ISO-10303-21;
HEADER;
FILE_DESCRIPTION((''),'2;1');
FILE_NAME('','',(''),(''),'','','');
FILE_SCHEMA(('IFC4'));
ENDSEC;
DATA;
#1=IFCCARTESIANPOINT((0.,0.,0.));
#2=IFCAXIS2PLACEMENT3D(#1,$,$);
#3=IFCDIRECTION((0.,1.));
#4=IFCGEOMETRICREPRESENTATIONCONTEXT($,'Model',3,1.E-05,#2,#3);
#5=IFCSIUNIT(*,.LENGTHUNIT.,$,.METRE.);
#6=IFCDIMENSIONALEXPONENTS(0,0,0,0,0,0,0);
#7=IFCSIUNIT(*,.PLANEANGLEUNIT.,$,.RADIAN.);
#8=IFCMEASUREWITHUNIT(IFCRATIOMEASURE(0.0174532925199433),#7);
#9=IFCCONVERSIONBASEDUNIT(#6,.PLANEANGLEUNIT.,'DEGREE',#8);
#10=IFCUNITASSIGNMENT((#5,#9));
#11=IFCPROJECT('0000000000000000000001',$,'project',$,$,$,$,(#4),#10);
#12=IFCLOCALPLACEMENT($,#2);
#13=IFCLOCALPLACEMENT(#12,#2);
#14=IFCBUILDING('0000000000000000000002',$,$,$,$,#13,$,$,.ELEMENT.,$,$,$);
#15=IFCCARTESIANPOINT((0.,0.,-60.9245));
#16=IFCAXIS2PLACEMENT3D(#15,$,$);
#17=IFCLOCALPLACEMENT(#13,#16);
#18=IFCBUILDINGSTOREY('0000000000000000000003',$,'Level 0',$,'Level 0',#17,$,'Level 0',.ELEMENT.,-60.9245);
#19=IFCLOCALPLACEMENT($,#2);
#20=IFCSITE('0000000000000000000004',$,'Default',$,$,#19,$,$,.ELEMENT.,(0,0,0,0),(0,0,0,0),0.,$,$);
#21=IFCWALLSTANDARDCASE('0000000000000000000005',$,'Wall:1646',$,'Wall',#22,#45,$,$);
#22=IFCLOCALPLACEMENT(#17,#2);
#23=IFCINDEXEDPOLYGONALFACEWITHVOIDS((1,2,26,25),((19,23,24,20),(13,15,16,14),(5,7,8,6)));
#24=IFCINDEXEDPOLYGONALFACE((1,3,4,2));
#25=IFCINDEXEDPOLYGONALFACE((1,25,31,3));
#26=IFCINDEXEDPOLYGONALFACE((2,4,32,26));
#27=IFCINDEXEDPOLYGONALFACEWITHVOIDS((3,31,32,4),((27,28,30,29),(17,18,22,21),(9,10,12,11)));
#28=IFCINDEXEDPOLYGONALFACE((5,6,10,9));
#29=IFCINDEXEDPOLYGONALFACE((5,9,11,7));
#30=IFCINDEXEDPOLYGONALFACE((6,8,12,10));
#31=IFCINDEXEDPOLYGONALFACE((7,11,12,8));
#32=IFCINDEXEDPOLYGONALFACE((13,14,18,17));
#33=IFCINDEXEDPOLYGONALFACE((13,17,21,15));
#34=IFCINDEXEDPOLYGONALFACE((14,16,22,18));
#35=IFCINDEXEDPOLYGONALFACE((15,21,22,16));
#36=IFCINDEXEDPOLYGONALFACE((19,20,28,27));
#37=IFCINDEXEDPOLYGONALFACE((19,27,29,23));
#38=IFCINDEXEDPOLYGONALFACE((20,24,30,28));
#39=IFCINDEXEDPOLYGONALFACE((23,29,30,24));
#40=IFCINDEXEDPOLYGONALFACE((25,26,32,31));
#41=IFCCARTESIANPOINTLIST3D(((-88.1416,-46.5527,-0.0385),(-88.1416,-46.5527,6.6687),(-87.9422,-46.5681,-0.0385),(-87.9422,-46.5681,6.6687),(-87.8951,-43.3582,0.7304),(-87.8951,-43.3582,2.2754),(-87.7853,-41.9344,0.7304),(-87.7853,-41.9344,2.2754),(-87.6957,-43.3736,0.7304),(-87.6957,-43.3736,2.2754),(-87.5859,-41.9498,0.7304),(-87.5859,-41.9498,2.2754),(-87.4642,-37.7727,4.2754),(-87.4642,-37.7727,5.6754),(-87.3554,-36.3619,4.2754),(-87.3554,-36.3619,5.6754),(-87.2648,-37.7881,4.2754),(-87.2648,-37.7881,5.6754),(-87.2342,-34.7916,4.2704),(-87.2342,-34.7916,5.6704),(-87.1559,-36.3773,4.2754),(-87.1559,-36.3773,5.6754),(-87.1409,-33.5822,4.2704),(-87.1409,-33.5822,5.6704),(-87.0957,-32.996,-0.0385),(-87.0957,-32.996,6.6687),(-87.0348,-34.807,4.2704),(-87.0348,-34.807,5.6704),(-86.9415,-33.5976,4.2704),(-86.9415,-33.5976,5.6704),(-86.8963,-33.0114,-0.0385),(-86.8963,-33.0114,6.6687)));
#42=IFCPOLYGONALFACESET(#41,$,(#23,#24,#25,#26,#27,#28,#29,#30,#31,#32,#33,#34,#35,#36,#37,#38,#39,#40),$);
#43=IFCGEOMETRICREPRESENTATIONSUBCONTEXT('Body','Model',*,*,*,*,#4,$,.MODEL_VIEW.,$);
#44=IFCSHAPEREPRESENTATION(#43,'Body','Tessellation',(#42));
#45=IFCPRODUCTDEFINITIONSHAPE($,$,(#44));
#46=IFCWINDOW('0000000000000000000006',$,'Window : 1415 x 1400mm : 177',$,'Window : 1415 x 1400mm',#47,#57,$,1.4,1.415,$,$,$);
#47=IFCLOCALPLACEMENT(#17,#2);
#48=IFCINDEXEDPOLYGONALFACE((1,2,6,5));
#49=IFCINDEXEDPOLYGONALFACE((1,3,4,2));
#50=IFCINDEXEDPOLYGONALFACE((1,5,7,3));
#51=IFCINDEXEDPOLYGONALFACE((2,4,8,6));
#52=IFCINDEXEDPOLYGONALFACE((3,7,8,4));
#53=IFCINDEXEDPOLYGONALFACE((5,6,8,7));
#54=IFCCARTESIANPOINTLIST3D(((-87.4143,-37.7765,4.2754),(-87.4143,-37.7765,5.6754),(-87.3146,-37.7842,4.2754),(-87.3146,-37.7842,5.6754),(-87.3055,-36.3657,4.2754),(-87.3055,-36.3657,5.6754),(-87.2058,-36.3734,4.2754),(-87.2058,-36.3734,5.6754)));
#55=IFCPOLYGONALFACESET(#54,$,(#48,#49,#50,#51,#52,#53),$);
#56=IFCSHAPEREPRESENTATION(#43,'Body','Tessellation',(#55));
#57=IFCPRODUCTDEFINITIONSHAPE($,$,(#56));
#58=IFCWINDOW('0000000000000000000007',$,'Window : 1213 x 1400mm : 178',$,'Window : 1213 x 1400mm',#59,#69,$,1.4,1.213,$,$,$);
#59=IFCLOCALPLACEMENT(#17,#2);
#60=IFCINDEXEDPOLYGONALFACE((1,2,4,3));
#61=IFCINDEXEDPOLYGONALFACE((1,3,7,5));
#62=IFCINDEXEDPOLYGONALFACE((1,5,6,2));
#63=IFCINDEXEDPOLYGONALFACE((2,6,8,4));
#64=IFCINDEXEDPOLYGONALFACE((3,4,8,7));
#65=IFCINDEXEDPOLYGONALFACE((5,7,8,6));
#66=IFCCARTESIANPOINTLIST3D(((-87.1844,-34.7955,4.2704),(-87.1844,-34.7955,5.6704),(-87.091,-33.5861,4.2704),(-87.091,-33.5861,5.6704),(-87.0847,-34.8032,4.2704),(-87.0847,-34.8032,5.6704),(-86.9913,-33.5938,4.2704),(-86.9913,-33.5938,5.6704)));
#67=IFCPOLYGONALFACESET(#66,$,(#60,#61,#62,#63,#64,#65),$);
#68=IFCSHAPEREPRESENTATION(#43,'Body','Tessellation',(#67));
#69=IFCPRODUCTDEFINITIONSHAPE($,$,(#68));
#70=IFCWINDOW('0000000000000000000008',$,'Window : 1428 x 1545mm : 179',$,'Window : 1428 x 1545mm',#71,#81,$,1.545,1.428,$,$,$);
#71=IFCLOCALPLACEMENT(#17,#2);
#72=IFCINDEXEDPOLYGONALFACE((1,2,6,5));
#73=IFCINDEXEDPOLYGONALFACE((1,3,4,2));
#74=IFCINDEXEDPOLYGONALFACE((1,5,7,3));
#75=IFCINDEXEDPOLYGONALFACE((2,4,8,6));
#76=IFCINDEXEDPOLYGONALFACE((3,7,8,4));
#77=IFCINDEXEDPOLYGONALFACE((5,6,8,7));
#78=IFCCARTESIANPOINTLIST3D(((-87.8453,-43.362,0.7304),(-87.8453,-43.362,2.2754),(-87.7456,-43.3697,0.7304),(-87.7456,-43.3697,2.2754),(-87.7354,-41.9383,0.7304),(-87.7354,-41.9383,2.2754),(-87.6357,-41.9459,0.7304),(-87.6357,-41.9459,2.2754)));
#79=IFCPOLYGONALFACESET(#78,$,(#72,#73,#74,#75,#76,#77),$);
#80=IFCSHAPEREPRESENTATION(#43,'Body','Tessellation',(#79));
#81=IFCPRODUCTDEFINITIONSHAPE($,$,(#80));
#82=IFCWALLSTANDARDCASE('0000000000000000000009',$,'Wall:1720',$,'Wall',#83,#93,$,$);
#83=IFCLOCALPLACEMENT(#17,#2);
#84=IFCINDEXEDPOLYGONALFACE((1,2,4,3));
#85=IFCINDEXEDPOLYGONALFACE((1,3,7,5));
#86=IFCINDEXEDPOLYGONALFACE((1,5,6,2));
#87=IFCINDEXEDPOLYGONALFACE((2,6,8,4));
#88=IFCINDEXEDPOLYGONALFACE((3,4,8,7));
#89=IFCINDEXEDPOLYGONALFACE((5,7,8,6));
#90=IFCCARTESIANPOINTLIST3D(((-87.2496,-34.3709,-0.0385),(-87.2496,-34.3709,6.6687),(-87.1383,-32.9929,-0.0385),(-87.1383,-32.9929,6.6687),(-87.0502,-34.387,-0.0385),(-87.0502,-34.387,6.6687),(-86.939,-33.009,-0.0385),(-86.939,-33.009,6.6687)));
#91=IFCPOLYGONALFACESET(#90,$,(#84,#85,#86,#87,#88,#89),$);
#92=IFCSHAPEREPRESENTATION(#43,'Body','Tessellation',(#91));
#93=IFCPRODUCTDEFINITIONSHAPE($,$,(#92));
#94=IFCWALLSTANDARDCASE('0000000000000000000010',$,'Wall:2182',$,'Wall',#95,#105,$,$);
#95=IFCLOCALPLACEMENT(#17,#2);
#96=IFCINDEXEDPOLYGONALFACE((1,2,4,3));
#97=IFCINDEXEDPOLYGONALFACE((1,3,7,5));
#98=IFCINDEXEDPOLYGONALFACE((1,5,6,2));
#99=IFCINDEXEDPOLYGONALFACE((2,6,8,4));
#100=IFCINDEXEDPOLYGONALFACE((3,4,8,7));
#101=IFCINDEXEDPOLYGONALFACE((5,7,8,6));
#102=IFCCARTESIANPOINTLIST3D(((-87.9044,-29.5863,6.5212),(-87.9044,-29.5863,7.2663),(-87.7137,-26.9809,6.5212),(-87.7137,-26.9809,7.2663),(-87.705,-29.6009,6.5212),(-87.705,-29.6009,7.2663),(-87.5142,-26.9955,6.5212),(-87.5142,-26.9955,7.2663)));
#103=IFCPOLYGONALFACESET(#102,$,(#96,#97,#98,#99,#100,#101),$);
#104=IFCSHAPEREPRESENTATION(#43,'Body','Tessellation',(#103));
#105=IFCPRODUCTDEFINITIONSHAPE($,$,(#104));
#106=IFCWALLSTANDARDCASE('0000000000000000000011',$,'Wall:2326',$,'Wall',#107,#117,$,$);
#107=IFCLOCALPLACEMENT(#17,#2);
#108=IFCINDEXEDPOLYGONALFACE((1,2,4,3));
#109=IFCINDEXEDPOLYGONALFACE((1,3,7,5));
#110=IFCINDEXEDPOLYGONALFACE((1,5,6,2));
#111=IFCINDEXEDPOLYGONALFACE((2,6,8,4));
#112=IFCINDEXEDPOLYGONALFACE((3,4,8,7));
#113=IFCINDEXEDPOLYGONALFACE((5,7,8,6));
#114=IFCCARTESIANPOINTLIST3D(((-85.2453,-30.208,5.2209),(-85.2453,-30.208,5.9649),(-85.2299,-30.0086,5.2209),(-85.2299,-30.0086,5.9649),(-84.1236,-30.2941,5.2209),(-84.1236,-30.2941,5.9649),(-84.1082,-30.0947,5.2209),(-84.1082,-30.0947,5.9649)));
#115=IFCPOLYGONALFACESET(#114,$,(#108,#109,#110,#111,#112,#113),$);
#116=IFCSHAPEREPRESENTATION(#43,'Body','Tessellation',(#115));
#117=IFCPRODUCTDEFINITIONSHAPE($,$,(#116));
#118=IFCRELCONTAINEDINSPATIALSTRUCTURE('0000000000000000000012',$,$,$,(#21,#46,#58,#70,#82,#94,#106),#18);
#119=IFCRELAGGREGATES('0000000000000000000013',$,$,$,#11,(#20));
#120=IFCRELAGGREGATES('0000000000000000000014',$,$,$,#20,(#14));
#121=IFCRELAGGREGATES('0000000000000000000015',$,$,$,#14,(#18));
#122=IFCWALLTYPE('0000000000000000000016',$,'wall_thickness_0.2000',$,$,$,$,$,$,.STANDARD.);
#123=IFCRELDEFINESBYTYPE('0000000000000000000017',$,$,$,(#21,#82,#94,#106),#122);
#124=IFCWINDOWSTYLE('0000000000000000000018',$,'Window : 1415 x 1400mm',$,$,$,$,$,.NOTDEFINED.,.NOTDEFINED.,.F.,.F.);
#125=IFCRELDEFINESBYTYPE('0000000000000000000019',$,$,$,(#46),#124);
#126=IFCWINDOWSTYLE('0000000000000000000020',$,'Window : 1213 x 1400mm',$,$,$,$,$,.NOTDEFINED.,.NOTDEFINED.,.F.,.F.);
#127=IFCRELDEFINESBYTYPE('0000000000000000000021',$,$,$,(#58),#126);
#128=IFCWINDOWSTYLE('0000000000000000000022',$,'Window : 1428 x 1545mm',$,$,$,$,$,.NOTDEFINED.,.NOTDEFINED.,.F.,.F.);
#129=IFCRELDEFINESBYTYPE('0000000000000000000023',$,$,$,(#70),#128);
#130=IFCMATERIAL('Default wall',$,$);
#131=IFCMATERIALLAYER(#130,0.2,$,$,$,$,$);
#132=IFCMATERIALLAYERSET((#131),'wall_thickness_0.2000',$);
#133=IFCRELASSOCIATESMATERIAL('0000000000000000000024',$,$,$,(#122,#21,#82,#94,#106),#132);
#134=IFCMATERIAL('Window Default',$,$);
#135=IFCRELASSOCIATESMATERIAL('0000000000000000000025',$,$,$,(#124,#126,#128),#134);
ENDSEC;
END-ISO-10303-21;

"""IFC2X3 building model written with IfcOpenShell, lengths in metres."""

from ifc_helpers import new_model, entity, si_unit, converted_unit, direction, frame, frame_2d, origin, origin_2d_with_axis, place, context, subcontext, project, spatial, polyline, rectangle, outline, extrude, source, transform, mapped, material, layer, layer_set, layer_usage, type_object, type_shapes, element, fill, save


model = new_model("IFC2X3")

# Units and contexts
model_context = context("Model", 3, precision=1e-05, world=origin(), true_north=direction((0.0, 1.0)))
body_context = subcontext(model_context, "Body", "Model", "MODEL_VIEW")
ifc_project = project(units=[si_unit("LENGTHUNIT", "METRE"), converted_unit("PLANEANGLEUNIT", "DEGREE", entity("IfcRatioMeasure", 0.0174532925199433), si_unit("PLANEANGLEUNIT", "RADIAN"), dimensions=[0, 0, 0, 0, 0, 0, 0])], contexts=[model_context])

# Site, building, storey
site_placement = place(None, origin())
site = spatial("IfcSite", under=ifc_project, at=site_placement, Name="Default", CompositionType="ELEMENT", RefLatitude=(0, 0, 0, 0), RefLongitude=(0, 0, 0, 0), RefElevation=0.0)
placement_1 = place(None, origin())
building_placement = place(placement_1, origin())
building = spatial("IfcBuilding", under=site, at=building_placement, CompositionType="ELEMENT")
storey_placement = place(building_placement, frame((0.0, 0.0, -60.9245)))
storey = spatial("IfcBuildingStorey", under=building, at=storey_placement, Name="Level 0", ObjectType="Level 0", LongName="Level 0", CompositionType="ELEMENT", Elevation=-60.9245)

# Shared definitions
ifc_material_1 = material(Name="Default wall")
ifc_layer = layer(ifc_material_1, 0.2)
ifc_layer_set = layer_set([ifc_layer], Name="wall_thickness_0.2000")
ifc_layer_usage = layer_usage(ifc_layer_set, "AXIS2", "POSITIVE", -0.1)
wall_type = type_object("IfcWallType", Name="wall_thickness_0.2000", PredefinedType="STANDARD", material=ifc_layer_set)

# Shared definitions
ifc_material_2 = material(Name="Window Default")

# Wall, openings, windows
placement_2 = place(building_placement, frame((0.0, 0.0, -60.963)))
wall_1_placement = place(placement_2, frame((-86.996, -33.0037, 0.0), z_axis=(0.0, 0.0, 1.0), x_axis=(-0.076921, -0.997037, 0.0)))
wall_1 = element("IfcWallStandardCase", 1, at=wall_1_placement, inside=storey, type_object=wall_type, material=ifc_layer_usage, Name="Wall:1646", ObjectType="Wall", context=body_context, shape_type="SweptSolid", body=[
    extrude(outline(polyline([(13.597, -0.1), (13.597, 0.1), (0.0, 0.1), (0.0, -0.1), (13.597, -0.1)])), origin(), (0.0, 0.0, 1.0), 6.7072),
])
opening_1_placement = place(wall_1_placement, frame((3.3759, -0.1, 4.314)))
opening_1 = element("IfcOpeningElement", 2, at=opening_1_placement, cuts=wall_1, ObjectType="Opening", context=body_context, shape_type="SweptSolid", body=[
    extrude(rectangle(XDim=1.415, YDim=1.4, at=frame_2d((0.7, 0.7075), x_axis=(0.0, 1.0))), frame((0.0, 0.0, 0.0), z_axis=(0.0, 1.0, 0.0), x_axis=(0.0, 0.0, 1.0)), (0.0, 0.0, 1.0), 0.2),
])
opening_2_placement = place(wall_1_placement, frame((0.588, -0.1, 4.309)))
opening_2 = element("IfcOpeningElement", 3, at=opening_2_placement, cuts=wall_1, ObjectType="Opening", context=body_context, shape_type="SweptSolid", body=[
    extrude(rectangle(XDim=1.213, YDim=1.4, at=frame_2d((0.7, 0.6065), x_axis=(0.0, 1.0))), frame((0.0, 0.0, 0.0), z_axis=(0.0, 1.0, 0.0), x_axis=(0.0, 0.0, 1.0)), (0.0, 0.0, 1.0), 0.2),
])
opening_3_placement = place(wall_1_placement, frame((8.965, -0.1, 0.769)))
opening_3 = element("IfcOpeningElement", 4, at=opening_3_placement, cuts=wall_1, ObjectType="Opening", context=body_context, shape_type="SweptSolid", body=[
    extrude(rectangle(XDim=1.428, YDim=1.545, at=frame_2d((0.7725, 0.714), x_axis=(0.0, 1.0))), frame((0.0, 0.0, 0.0), z_axis=(0.0, 1.0, 0.0), x_axis=(0.0, 0.0, 1.0)), (0.0, 0.0, 1.0), 0.2),
])
window_style_1 = type_object("IfcWindowStyle", Name="Window : 1415 x 1400mm", ConstructionType="NOTDEFINED", OperationType="NOTDEFINED", ParameterTakesPrecedence=False, Sizeable=False, material=ifc_material_2)
shared_shape_1 = source(origin(), body_context, "Body", "SweptSolid", [
    extrude(rectangle(XDim=0.1, YDim=1.415, at=origin_2d_with_axis()), frame((0.7075, 0.1, 0.0), z_axis=(0.0, 0.0, 1.0), x_axis=(0.0, 1.0, 0.0)), (0.0, 0.0, 1.0), 1.4),
])
type_shapes(window_style_1, [shared_shape_1])
window_1_placement = place(opening_1_placement, origin())
window_1 = element("IfcWindow", 5, at=window_1_placement, inside=storey, type_object=window_style_1, Name="Window : 1415 x 1400mm : 177", ObjectType="Window : 1415 x 1400mm", OverallHeight=1.4, OverallWidth=1.415, context=body_context, shape_type="MappedRepresentation", body=[
    mapped(shared_shape_1, transform((0.0, 0.0, 0.0), scale=1.0)),
])
fill(opening_1, window_1)
window_style_2 = type_object("IfcWindowStyle", Name="Window : 1213 x 1400mm", ConstructionType="NOTDEFINED", OperationType="NOTDEFINED", ParameterTakesPrecedence=False, Sizeable=False, material=ifc_material_2)
shared_shape_2 = source(origin(), body_context, "Body", "SweptSolid", [
    extrude(rectangle(XDim=0.1, YDim=1.213, at=origin_2d_with_axis()), frame((0.6065, 0.1, 0.0), z_axis=(0.0, 0.0, 1.0), x_axis=(0.0, 1.0, 0.0)), (0.0, 0.0, 1.0), 1.4),
])
type_shapes(window_style_2, [shared_shape_2])
window_2_placement = place(opening_2_placement, origin())
window_2 = element("IfcWindow", 6, at=window_2_placement, inside=storey, type_object=window_style_2, Name="Window : 1213 x 1400mm : 178", ObjectType="Window : 1213 x 1400mm", OverallHeight=1.4, OverallWidth=1.213, context=body_context, shape_type="MappedRepresentation", body=[
    mapped(shared_shape_2, transform((0.0, 0.0, 0.0), scale=1.0)),
])
fill(opening_2, window_2)
window_style_3 = type_object("IfcWindowStyle", Name="Window : 1428 x 1545mm", ConstructionType="NOTDEFINED", OperationType="NOTDEFINED", ParameterTakesPrecedence=False, Sizeable=False, material=ifc_material_2)
shared_shape_3 = source(origin(), body_context, "Body", "SweptSolid", [
    extrude(rectangle(XDim=0.1, YDim=1.428, at=origin_2d_with_axis()), frame((0.714, 0.1, 0.0), z_axis=(0.0, 0.0, 1.0), x_axis=(0.0, 1.0, 0.0)), (0.0, 0.0, 1.0), 1.545),
])
type_shapes(window_style_3, [shared_shape_3])
window_3_placement = place(opening_3_placement, origin())
window_3 = element("IfcWindow", 7, at=window_3_placement, inside=storey, type_object=window_style_3, Name="Window : 1428 x 1545mm : 179", ObjectType="Window : 1428 x 1545mm", OverallHeight=1.545, OverallWidth=1.428, context=body_context, shape_type="MappedRepresentation", body=[
    mapped(shared_shape_3, transform((0.0, 0.0, 0.0), scale=1.0)),
])
fill(opening_3, window_3)

# Walls
placement_3 = place(building_placement, frame((0.0, 0.0, -60.963)))
wall_2_placement = place(placement_3, frame((-87.0386, -33.001, 0.0), z_axis=(0.0, 0.0, 1.0), x_axis=(-0.080471, -0.996757, 0.0)))
element("IfcWallStandardCase", 8, at=wall_2_placement, inside=storey, type_object=wall_type, material=ifc_layer_usage, Name="Wall:1720", ObjectType="Wall", context=body_context, shape_type="SweptSolid", body=[
    extrude(outline(polyline([(1.3824, -0.1), (1.3824, 0.1), (0.0, 0.1), (0.0, -0.1), (1.3824, -0.1)])), origin(), (0.0, 0.0, 1.0), 6.7072),
])
placement_4 = place(building_placement, frame((0.0, 0.0, -54.4033)))
wall_3_placement = place(placement_4, frame((-87.8047, -29.5936, 0.0), z_axis=(0.0, 0.0, 1.0), x_axis=(0.073019, 0.997331, 0.0)))
element("IfcWallStandardCase", 9, at=wall_3_placement, inside=storey, type_object=wall_type, material=ifc_layer_usage, Name="Wall:2182", ObjectType="Wall", context=body_context, shape_type="SweptSolid", body=[
    extrude(outline(polyline([(2.6123, -0.1), (2.6123, 0.1), (0.0, 0.1), (0.0, -0.1), (2.6123, -0.1)])), origin(), (0.0, 0.0, 1.0), 0.7451),
])
placement_5 = place(building_placement, frame((0.0, 0.0, -55.7036)))
wall_4_placement = place(placement_5, frame((-85.2376, -30.1083, 0.0), z_axis=(0.0, 0.0, 1.0), x_axis=(0.997064, -0.07657, 0.0)))
element("IfcWallStandardCase", 10, at=wall_4_placement, inside=storey, type_object=wall_type, material=ifc_layer_usage, Name="Wall:2326", ObjectType="Wall", context=body_context, shape_type="SweptSolid", body=[
    extrude(outline(polyline([(1.125, -0.1), (1.125, 0.1), (0.0, 0.1), (0.0, -0.1), (1.125, -0.1)])), origin(), (0.0, 0.0, 1.0), 0.744),
])

save(model, "model.ifc")
